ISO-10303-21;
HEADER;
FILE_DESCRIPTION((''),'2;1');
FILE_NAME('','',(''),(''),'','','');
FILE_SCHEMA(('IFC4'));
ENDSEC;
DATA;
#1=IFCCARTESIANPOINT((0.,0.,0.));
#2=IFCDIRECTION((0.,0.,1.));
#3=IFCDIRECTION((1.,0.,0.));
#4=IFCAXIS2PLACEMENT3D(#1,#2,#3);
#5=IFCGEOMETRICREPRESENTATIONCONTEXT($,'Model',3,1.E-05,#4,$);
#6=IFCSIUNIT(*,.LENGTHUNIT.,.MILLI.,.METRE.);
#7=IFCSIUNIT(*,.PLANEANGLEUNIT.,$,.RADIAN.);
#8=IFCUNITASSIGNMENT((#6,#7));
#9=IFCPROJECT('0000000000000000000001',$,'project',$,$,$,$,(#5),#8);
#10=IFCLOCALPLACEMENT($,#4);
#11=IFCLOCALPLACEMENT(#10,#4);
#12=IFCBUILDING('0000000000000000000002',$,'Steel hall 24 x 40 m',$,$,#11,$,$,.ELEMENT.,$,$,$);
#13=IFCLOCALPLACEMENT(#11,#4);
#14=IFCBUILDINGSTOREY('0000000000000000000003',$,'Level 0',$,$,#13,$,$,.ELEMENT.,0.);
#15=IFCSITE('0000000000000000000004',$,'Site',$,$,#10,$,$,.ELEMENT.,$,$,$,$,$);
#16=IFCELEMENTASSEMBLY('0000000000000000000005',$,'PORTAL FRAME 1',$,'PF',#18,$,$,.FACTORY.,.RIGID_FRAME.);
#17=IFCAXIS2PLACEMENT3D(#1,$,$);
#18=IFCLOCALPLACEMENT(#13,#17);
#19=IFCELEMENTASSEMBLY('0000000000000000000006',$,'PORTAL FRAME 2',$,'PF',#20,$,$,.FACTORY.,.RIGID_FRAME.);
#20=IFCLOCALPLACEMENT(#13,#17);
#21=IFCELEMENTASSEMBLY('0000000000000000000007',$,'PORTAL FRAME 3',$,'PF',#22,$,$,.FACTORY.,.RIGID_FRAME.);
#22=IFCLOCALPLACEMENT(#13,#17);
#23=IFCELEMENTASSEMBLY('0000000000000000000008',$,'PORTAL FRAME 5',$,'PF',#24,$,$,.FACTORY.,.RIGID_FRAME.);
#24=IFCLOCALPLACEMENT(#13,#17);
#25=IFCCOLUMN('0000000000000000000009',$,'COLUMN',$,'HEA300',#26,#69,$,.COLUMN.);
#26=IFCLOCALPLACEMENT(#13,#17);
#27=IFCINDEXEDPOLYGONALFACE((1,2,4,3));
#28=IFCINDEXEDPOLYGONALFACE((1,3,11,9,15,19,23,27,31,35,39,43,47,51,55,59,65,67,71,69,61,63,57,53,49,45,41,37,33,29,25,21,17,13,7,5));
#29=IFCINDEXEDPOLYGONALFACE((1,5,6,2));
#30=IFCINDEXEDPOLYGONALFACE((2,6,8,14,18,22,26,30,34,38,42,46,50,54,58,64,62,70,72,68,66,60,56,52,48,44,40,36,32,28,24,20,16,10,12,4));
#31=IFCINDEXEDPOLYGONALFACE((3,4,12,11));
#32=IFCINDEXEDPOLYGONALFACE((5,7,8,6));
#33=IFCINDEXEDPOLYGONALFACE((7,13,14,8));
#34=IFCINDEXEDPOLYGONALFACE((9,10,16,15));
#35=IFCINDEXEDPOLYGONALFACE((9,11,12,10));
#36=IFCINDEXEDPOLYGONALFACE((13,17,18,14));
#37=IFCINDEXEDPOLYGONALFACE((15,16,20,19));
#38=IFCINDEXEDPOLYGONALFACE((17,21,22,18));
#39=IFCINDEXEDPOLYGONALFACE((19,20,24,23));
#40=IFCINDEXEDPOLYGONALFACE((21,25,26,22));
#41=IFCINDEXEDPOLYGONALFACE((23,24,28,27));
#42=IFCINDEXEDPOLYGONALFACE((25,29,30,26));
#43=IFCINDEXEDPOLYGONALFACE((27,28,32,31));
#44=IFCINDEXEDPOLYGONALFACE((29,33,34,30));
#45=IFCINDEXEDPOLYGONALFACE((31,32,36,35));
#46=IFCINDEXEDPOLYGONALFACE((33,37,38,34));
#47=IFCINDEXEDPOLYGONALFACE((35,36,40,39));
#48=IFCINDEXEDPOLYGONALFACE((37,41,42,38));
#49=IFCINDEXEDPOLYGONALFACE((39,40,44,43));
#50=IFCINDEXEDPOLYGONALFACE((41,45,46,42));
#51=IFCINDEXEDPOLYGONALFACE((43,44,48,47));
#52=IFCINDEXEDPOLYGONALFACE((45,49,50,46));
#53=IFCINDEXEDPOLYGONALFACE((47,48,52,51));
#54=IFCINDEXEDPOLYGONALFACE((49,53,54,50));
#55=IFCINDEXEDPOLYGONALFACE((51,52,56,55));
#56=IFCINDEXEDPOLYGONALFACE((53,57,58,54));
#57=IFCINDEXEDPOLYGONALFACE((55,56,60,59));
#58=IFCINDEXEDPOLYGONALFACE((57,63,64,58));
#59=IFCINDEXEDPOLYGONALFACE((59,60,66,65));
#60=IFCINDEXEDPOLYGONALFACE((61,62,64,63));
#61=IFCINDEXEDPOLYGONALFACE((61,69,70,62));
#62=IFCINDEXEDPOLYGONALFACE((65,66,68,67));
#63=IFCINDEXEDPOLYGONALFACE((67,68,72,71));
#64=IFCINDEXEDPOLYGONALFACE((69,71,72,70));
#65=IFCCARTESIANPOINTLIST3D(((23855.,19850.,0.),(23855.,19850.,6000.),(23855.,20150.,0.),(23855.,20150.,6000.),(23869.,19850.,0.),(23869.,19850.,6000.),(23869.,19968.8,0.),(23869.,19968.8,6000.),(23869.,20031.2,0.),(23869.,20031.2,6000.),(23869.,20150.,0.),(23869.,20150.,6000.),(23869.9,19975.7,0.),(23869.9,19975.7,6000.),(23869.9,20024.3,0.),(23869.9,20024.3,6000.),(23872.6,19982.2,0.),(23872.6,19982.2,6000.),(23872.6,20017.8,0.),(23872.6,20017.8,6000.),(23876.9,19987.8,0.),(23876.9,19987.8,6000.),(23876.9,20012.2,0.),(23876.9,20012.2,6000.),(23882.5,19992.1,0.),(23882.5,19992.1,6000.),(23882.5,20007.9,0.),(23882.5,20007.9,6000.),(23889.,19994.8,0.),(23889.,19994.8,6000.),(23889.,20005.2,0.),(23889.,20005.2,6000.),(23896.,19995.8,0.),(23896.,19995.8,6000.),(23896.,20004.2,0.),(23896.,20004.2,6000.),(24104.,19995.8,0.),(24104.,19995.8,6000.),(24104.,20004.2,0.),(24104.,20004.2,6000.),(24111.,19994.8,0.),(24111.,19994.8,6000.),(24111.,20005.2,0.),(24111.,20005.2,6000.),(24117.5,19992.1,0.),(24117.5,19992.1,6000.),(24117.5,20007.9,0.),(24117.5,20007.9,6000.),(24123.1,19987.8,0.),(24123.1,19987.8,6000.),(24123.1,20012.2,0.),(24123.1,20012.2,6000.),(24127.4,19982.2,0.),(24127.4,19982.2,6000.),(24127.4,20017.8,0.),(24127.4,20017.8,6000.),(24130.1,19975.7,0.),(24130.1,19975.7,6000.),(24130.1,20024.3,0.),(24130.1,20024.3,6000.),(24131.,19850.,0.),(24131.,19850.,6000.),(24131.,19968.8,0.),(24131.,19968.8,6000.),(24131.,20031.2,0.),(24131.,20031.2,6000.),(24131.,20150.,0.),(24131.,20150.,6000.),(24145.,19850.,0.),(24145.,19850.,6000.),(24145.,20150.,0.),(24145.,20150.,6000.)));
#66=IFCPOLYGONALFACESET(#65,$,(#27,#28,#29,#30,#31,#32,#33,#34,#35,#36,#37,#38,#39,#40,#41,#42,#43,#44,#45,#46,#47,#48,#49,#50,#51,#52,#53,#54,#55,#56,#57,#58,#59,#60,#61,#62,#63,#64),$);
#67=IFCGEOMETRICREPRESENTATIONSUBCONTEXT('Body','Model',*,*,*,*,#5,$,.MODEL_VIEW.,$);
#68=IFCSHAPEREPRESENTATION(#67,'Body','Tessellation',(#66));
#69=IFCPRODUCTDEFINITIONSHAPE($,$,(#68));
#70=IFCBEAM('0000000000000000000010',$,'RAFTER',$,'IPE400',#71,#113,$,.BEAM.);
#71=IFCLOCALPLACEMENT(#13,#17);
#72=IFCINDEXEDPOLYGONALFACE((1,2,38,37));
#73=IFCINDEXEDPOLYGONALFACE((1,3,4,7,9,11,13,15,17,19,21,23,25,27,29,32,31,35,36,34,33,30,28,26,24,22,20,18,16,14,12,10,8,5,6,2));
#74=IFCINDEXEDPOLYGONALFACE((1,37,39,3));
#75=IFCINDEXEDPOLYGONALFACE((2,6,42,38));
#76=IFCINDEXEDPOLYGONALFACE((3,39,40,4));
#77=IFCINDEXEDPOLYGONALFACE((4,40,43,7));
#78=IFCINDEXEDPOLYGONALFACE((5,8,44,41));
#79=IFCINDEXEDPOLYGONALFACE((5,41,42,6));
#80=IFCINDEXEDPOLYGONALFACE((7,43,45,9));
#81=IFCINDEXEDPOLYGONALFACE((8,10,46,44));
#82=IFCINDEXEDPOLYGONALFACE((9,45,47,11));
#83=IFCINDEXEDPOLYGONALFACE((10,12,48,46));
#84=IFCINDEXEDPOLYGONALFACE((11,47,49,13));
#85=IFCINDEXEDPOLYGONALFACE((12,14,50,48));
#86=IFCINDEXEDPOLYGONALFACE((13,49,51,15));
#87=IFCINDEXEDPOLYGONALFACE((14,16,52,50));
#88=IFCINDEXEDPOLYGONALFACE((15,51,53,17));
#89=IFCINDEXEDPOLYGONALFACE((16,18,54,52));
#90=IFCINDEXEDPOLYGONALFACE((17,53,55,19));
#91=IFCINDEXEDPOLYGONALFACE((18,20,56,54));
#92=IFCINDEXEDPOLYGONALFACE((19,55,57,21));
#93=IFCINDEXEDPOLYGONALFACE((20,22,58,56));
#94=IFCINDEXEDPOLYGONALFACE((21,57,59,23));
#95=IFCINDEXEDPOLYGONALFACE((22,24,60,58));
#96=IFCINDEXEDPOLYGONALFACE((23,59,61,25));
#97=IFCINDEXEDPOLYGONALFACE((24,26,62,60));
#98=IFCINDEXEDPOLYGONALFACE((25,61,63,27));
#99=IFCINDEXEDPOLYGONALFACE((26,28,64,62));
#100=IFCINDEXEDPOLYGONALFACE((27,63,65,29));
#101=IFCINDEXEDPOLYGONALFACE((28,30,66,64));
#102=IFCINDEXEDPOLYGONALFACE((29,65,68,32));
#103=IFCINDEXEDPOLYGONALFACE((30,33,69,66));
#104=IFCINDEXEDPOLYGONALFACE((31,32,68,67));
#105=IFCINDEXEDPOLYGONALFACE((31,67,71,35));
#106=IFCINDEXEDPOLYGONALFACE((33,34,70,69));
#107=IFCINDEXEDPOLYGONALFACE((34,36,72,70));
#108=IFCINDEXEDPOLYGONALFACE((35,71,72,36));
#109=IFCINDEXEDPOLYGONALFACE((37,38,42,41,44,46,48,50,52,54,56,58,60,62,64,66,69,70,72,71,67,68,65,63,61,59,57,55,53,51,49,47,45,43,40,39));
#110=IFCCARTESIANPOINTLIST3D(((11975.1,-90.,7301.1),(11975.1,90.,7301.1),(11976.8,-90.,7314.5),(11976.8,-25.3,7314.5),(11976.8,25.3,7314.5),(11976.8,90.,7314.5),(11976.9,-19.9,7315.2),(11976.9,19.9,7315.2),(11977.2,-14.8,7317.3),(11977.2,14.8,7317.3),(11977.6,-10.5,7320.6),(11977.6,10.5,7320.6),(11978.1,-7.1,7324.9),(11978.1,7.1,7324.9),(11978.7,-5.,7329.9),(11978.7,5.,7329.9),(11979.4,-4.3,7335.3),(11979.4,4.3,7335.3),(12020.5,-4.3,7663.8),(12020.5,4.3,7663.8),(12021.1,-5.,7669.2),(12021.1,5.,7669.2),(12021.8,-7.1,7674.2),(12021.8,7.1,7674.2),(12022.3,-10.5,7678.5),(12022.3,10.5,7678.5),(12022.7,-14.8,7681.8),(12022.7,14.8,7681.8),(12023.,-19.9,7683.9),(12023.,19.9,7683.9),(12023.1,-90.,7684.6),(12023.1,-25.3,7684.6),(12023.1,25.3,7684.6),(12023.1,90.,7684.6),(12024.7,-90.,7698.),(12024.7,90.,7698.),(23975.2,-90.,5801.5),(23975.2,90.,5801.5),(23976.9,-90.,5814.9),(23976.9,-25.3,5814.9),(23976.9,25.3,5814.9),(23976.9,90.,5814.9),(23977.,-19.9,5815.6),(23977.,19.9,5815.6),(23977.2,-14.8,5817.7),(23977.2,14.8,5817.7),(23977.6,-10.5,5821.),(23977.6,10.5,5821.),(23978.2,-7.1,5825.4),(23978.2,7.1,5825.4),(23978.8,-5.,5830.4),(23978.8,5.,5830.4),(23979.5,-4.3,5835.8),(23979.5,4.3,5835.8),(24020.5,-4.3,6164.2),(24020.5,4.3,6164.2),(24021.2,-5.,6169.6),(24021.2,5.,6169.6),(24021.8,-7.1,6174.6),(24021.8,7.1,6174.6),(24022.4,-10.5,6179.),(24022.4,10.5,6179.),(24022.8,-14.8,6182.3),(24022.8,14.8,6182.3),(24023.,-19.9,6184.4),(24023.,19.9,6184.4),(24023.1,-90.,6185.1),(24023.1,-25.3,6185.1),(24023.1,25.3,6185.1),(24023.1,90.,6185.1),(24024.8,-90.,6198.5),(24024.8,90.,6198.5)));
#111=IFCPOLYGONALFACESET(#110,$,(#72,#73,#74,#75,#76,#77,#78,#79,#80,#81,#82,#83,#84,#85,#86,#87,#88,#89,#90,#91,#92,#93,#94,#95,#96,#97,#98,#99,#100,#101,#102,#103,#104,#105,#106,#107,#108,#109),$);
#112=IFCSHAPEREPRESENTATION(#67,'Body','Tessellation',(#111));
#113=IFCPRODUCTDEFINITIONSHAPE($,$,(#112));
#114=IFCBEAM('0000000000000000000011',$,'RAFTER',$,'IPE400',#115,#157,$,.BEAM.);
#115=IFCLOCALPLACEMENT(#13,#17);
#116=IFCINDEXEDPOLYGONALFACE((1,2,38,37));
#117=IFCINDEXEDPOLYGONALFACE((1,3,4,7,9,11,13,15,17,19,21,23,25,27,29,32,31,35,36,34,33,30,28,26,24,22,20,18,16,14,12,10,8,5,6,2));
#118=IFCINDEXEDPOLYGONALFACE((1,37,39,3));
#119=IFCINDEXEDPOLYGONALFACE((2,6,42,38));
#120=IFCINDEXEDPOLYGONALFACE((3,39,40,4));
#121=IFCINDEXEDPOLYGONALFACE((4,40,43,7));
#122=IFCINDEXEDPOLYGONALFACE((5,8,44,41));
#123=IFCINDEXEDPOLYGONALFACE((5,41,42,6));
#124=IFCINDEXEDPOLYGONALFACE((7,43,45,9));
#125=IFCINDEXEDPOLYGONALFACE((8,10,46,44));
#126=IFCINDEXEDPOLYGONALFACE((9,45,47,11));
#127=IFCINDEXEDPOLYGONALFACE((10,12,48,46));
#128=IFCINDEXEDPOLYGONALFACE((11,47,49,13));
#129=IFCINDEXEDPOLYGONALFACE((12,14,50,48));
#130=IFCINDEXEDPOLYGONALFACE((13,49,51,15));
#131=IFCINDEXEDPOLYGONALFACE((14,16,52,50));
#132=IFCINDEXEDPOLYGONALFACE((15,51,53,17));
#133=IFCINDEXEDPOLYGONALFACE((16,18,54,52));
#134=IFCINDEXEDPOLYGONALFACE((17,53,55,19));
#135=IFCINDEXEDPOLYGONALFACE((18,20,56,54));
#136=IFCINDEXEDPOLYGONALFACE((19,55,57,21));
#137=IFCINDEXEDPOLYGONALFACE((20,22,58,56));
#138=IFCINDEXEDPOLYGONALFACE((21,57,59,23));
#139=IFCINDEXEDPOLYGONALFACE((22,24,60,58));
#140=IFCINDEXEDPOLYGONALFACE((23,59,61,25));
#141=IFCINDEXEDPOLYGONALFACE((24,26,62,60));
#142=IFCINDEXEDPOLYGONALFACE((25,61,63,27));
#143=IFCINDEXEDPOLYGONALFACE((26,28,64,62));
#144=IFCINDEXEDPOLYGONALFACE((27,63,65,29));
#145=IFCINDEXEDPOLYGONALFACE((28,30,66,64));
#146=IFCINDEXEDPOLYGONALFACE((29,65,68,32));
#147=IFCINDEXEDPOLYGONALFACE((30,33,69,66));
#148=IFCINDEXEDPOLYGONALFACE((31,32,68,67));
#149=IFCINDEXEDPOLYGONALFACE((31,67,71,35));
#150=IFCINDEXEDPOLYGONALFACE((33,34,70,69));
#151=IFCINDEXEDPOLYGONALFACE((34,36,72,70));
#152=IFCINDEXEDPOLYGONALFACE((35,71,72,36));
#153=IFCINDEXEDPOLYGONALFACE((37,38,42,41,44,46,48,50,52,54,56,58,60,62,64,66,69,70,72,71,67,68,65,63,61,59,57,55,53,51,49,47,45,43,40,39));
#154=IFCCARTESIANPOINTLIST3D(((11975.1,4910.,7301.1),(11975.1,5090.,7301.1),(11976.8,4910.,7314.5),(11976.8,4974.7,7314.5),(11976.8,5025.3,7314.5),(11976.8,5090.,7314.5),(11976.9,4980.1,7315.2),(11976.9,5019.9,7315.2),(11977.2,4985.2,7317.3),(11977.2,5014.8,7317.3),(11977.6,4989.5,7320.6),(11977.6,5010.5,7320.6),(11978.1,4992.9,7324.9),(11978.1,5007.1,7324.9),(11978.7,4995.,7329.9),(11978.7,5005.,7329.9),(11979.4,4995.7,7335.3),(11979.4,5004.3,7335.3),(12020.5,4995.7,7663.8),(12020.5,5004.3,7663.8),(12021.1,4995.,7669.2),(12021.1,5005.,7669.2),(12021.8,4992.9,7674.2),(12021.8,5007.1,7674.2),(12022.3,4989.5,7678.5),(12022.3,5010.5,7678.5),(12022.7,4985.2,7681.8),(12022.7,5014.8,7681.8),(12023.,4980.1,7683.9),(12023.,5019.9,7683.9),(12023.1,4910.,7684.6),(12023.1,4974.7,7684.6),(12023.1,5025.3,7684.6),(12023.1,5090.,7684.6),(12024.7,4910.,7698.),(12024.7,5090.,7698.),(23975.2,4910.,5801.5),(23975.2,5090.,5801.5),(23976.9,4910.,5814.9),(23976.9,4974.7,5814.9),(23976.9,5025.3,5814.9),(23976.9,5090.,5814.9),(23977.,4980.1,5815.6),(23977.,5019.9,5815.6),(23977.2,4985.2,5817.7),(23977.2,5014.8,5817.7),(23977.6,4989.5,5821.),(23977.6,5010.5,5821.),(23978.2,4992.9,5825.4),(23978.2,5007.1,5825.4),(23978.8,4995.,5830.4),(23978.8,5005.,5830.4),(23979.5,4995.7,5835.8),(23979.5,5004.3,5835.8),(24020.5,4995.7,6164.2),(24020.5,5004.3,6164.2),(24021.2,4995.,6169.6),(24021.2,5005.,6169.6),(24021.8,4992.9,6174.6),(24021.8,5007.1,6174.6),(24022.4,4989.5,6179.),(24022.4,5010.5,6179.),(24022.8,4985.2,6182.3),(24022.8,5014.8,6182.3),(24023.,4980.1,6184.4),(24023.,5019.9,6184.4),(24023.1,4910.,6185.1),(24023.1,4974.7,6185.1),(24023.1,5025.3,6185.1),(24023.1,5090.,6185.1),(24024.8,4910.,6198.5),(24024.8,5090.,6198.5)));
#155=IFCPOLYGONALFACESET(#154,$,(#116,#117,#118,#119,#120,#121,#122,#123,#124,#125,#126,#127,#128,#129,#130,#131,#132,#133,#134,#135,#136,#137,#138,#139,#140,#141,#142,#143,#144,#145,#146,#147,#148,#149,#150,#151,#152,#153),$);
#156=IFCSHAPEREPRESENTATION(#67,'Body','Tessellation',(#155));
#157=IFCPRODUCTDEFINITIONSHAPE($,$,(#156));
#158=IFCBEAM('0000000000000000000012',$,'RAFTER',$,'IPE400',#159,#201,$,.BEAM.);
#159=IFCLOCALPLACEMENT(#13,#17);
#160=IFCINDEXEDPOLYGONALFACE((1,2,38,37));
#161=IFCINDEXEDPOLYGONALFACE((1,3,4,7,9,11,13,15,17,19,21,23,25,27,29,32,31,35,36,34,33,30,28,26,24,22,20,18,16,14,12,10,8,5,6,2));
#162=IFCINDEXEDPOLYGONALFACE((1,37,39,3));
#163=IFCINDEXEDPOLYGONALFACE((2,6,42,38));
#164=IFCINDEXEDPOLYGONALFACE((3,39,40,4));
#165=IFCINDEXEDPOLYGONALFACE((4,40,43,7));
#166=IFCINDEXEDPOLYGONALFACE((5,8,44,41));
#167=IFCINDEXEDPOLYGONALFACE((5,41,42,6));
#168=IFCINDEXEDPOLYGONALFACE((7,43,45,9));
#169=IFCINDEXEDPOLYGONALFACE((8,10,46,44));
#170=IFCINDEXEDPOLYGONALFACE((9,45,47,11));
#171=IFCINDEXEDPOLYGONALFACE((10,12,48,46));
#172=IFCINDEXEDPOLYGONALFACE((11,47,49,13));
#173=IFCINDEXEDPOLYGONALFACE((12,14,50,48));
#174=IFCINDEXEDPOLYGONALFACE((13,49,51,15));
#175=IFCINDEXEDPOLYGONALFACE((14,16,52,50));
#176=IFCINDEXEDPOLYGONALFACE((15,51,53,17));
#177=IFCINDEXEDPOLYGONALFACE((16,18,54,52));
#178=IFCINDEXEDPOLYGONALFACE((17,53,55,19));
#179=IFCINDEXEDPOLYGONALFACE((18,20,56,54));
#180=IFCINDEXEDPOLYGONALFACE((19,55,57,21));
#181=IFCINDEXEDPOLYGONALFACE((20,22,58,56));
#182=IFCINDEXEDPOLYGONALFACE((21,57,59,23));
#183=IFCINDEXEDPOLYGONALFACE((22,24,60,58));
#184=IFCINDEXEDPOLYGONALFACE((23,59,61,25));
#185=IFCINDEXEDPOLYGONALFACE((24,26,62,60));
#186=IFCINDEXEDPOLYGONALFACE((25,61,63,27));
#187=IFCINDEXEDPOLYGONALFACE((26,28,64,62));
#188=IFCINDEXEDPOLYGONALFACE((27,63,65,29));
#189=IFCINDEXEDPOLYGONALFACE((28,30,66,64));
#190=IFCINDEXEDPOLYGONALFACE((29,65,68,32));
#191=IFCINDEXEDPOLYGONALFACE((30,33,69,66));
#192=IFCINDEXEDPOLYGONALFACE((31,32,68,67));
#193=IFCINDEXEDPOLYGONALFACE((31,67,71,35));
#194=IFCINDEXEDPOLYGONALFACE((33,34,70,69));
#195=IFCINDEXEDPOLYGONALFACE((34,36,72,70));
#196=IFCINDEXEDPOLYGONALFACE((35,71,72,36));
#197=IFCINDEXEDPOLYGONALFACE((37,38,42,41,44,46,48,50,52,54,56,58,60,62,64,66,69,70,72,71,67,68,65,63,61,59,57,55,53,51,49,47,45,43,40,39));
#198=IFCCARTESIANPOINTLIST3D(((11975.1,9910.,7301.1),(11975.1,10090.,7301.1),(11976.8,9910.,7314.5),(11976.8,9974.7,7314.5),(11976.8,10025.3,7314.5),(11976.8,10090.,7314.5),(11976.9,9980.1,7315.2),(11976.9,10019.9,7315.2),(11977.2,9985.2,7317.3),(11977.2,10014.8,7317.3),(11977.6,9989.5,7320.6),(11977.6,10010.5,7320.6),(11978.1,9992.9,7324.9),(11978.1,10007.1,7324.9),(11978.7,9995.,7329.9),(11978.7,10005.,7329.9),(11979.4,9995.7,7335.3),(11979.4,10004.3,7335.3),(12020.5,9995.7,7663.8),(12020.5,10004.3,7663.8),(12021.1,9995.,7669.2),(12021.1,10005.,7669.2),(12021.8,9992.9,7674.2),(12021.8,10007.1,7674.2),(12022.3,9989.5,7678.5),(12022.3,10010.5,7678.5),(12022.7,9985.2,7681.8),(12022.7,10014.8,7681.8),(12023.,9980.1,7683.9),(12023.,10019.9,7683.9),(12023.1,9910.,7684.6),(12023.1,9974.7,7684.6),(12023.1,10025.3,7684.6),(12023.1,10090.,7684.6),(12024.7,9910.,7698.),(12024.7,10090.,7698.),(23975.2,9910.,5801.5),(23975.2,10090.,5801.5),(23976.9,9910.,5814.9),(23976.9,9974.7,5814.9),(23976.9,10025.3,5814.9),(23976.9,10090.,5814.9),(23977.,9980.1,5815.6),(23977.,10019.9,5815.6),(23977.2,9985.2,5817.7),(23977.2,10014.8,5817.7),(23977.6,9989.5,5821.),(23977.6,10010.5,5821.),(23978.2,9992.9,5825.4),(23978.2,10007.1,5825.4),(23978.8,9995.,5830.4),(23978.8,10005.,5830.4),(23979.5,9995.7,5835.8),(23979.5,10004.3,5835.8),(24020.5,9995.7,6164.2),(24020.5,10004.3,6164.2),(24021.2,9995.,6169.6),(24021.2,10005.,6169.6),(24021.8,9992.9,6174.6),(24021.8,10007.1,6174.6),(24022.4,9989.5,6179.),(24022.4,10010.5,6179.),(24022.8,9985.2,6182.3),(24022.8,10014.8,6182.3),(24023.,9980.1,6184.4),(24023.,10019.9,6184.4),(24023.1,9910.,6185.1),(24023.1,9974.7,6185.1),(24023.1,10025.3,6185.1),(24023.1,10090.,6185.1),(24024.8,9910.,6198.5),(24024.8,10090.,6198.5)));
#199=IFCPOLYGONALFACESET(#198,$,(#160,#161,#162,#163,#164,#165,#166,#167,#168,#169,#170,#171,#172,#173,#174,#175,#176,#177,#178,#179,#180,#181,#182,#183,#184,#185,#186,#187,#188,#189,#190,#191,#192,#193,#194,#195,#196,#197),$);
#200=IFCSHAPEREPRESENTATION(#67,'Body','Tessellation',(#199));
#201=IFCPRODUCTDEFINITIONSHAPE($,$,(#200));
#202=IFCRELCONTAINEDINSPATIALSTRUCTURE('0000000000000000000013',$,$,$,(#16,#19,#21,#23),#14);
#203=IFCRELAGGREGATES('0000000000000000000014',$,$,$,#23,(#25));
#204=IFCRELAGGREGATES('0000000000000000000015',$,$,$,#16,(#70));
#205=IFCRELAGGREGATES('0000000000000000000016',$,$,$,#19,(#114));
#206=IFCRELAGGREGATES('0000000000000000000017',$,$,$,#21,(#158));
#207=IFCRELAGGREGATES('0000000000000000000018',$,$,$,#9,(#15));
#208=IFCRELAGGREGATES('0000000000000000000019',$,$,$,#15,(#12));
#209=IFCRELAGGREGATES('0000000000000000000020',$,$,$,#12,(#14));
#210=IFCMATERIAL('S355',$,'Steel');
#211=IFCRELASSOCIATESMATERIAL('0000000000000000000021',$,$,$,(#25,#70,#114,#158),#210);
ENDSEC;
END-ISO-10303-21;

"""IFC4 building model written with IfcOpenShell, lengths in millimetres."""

from ifc_helpers import new_model, si_unit, frame, origin_with_axes, place, context, subcontext, project, spatial, i_section, extrude, material, element, aggregate, save


model = new_model("IFC4")

# Units and contexts
model_context = context("Model", 3, precision=1e-05, world=origin_with_axes())
body_context = subcontext(model_context, "Body", "Model", "MODEL_VIEW")
ifc_project = project(units=[si_unit("LENGTHUNIT", "METRE", prefix="MILLI"), si_unit("PLANEANGLEUNIT", "RADIAN")], contexts=[model_context])

# Site, building, storey
site_placement = place(None, origin_with_axes())
site = spatial("IfcSite", under=ifc_project, at=site_placement, Name="Site", CompositionType="ELEMENT")
building_placement = place(site_placement, origin_with_axes())
building = spatial("IfcBuilding", under=site, at=building_placement, Name="Steel hall 24 x 40 m", CompositionType="ELEMENT")
storey_placement = place(building_placement, origin_with_axes())
storey = spatial("IfcBuildingStorey", under=building, at=storey_placement, Name="Level 0", CompositionType="ELEMENT", Elevation=0.0)

# Element assemblies, column
assembly_1_placement = place(storey_placement, origin_with_axes())
assembly_1 = element("IfcElementAssembly", 1, at=assembly_1_placement, inside=storey, Name="PORTAL FRAME 1", ObjectType="PF", AssemblyPlace="FACTORY", PredefinedType="RIGID_FRAME")
ifc_material = material(Name="S355", Category="Steel")
assembly_2_placement = place(storey_placement, frame((0.0, 5000.0, 0.0), z_axis=(0.0, 0.0, 1.0), x_axis=(1.0, 0.0, 0.0)))
assembly_2 = element("IfcElementAssembly", 2, at=assembly_2_placement, inside=storey, Name="PORTAL FRAME 2", ObjectType="PF", AssemblyPlace="FACTORY", PredefinedType="RIGID_FRAME")
assembly_3_placement = place(storey_placement, frame((0.0, 10000.0, 0.0), z_axis=(0.0, 0.0, 1.0), x_axis=(1.0, 0.0, 0.0)))
assembly_3 = element("IfcElementAssembly", 3, at=assembly_3_placement, inside=storey, Name="PORTAL FRAME 3", ObjectType="PF", AssemblyPlace="FACTORY", PredefinedType="RIGID_FRAME")
assembly_4_placement = place(storey_placement, frame((0.0, 20000.0, 0.0), z_axis=(0.0, 0.0, 1.0), x_axis=(1.0, 0.0, 0.0)))
assembly_4 = element("IfcElementAssembly", 4, at=assembly_4_placement, inside=storey, Name="PORTAL FRAME 5", ObjectType="PF", AssemblyPlace="FACTORY", PredefinedType="RIGID_FRAME")
column_1_placement = place(storey_placement, frame((24000.0, 20000.0, 0.0), z_axis=(0.0, 0.0, 1.0), x_axis=(0.0, 1.0, 0.0)))
column_1 = element("IfcColumn", 5, at=column_1_placement, material=ifc_material, Name="COLUMN", ObjectType="HEA300", PredefinedType="COLUMN", context=body_context, shape_type="SweptSolid", body=[
    extrude(i_section(OverallWidth=300.0, OverallDepth=290.0, WebThickness=8.5, FlangeThickness=14.0, FilletRadius=27.0), origin_with_axes(), (0.0, 0.0, 1.0), 6000.0),
])
aggregate(assembly_4, [column_1])

# Beams
beam_1_placement = place(storey_placement, frame((24000.0, 0.0, 6000.0), z_axis=(-0.9923, 0.0, 0.124), x_axis=(0.0, 1.0, 0.0)))
beam_1 = element("IfcBeam", 6, at=beam_1_placement, material=ifc_material, Name="RAFTER", ObjectType="IPE400", PredefinedType="BEAM", context=body_context, shape_type="SweptSolid", body=[
    extrude(i_section(OverallWidth=180.0, OverallDepth=400.0, WebThickness=8.6, FlangeThickness=13.5, FilletRadius=21.0), origin_with_axes(), (0.0, 0.0, 1.0), 12093.4),
])
beam_2_placement = place(storey_placement, frame((24000.0, 5000.0, 6000.0), z_axis=(-0.9923, 0.0, 0.124), x_axis=(0.0, 1.0, 0.0)))
beam_2 = element("IfcBeam", 7, at=beam_2_placement, material=ifc_material, Name="RAFTER", ObjectType="IPE400", PredefinedType="BEAM", context=body_context, shape_type="SweptSolid", body=[
    extrude(i_section(OverallWidth=180.0, OverallDepth=400.0, WebThickness=8.6, FlangeThickness=13.5, FilletRadius=21.0), origin_with_axes(), (0.0, 0.0, 1.0), 12093.4),
])
beam_3_placement = place(storey_placement, frame((24000.0, 10000.0, 6000.0), z_axis=(-0.9923, 0.0, 0.124), x_axis=(0.0, 1.0, 0.0)))
beam_3 = element("IfcBeam", 8, at=beam_3_placement, material=ifc_material, Name="RAFTER", ObjectType="IPE400", PredefinedType="BEAM", context=body_context, shape_type="SweptSolid", body=[
    extrude(i_section(OverallWidth=180.0, OverallDepth=400.0, WebThickness=8.6, FlangeThickness=13.5, FilletRadius=21.0), origin_with_axes(), (0.0, 0.0, 1.0), 12093.4),
])

aggregate(assembly_1, [beam_1])
aggregate(assembly_2, [beam_2])
aggregate(assembly_3, [beam_3])

save(model, "model.ifc")
